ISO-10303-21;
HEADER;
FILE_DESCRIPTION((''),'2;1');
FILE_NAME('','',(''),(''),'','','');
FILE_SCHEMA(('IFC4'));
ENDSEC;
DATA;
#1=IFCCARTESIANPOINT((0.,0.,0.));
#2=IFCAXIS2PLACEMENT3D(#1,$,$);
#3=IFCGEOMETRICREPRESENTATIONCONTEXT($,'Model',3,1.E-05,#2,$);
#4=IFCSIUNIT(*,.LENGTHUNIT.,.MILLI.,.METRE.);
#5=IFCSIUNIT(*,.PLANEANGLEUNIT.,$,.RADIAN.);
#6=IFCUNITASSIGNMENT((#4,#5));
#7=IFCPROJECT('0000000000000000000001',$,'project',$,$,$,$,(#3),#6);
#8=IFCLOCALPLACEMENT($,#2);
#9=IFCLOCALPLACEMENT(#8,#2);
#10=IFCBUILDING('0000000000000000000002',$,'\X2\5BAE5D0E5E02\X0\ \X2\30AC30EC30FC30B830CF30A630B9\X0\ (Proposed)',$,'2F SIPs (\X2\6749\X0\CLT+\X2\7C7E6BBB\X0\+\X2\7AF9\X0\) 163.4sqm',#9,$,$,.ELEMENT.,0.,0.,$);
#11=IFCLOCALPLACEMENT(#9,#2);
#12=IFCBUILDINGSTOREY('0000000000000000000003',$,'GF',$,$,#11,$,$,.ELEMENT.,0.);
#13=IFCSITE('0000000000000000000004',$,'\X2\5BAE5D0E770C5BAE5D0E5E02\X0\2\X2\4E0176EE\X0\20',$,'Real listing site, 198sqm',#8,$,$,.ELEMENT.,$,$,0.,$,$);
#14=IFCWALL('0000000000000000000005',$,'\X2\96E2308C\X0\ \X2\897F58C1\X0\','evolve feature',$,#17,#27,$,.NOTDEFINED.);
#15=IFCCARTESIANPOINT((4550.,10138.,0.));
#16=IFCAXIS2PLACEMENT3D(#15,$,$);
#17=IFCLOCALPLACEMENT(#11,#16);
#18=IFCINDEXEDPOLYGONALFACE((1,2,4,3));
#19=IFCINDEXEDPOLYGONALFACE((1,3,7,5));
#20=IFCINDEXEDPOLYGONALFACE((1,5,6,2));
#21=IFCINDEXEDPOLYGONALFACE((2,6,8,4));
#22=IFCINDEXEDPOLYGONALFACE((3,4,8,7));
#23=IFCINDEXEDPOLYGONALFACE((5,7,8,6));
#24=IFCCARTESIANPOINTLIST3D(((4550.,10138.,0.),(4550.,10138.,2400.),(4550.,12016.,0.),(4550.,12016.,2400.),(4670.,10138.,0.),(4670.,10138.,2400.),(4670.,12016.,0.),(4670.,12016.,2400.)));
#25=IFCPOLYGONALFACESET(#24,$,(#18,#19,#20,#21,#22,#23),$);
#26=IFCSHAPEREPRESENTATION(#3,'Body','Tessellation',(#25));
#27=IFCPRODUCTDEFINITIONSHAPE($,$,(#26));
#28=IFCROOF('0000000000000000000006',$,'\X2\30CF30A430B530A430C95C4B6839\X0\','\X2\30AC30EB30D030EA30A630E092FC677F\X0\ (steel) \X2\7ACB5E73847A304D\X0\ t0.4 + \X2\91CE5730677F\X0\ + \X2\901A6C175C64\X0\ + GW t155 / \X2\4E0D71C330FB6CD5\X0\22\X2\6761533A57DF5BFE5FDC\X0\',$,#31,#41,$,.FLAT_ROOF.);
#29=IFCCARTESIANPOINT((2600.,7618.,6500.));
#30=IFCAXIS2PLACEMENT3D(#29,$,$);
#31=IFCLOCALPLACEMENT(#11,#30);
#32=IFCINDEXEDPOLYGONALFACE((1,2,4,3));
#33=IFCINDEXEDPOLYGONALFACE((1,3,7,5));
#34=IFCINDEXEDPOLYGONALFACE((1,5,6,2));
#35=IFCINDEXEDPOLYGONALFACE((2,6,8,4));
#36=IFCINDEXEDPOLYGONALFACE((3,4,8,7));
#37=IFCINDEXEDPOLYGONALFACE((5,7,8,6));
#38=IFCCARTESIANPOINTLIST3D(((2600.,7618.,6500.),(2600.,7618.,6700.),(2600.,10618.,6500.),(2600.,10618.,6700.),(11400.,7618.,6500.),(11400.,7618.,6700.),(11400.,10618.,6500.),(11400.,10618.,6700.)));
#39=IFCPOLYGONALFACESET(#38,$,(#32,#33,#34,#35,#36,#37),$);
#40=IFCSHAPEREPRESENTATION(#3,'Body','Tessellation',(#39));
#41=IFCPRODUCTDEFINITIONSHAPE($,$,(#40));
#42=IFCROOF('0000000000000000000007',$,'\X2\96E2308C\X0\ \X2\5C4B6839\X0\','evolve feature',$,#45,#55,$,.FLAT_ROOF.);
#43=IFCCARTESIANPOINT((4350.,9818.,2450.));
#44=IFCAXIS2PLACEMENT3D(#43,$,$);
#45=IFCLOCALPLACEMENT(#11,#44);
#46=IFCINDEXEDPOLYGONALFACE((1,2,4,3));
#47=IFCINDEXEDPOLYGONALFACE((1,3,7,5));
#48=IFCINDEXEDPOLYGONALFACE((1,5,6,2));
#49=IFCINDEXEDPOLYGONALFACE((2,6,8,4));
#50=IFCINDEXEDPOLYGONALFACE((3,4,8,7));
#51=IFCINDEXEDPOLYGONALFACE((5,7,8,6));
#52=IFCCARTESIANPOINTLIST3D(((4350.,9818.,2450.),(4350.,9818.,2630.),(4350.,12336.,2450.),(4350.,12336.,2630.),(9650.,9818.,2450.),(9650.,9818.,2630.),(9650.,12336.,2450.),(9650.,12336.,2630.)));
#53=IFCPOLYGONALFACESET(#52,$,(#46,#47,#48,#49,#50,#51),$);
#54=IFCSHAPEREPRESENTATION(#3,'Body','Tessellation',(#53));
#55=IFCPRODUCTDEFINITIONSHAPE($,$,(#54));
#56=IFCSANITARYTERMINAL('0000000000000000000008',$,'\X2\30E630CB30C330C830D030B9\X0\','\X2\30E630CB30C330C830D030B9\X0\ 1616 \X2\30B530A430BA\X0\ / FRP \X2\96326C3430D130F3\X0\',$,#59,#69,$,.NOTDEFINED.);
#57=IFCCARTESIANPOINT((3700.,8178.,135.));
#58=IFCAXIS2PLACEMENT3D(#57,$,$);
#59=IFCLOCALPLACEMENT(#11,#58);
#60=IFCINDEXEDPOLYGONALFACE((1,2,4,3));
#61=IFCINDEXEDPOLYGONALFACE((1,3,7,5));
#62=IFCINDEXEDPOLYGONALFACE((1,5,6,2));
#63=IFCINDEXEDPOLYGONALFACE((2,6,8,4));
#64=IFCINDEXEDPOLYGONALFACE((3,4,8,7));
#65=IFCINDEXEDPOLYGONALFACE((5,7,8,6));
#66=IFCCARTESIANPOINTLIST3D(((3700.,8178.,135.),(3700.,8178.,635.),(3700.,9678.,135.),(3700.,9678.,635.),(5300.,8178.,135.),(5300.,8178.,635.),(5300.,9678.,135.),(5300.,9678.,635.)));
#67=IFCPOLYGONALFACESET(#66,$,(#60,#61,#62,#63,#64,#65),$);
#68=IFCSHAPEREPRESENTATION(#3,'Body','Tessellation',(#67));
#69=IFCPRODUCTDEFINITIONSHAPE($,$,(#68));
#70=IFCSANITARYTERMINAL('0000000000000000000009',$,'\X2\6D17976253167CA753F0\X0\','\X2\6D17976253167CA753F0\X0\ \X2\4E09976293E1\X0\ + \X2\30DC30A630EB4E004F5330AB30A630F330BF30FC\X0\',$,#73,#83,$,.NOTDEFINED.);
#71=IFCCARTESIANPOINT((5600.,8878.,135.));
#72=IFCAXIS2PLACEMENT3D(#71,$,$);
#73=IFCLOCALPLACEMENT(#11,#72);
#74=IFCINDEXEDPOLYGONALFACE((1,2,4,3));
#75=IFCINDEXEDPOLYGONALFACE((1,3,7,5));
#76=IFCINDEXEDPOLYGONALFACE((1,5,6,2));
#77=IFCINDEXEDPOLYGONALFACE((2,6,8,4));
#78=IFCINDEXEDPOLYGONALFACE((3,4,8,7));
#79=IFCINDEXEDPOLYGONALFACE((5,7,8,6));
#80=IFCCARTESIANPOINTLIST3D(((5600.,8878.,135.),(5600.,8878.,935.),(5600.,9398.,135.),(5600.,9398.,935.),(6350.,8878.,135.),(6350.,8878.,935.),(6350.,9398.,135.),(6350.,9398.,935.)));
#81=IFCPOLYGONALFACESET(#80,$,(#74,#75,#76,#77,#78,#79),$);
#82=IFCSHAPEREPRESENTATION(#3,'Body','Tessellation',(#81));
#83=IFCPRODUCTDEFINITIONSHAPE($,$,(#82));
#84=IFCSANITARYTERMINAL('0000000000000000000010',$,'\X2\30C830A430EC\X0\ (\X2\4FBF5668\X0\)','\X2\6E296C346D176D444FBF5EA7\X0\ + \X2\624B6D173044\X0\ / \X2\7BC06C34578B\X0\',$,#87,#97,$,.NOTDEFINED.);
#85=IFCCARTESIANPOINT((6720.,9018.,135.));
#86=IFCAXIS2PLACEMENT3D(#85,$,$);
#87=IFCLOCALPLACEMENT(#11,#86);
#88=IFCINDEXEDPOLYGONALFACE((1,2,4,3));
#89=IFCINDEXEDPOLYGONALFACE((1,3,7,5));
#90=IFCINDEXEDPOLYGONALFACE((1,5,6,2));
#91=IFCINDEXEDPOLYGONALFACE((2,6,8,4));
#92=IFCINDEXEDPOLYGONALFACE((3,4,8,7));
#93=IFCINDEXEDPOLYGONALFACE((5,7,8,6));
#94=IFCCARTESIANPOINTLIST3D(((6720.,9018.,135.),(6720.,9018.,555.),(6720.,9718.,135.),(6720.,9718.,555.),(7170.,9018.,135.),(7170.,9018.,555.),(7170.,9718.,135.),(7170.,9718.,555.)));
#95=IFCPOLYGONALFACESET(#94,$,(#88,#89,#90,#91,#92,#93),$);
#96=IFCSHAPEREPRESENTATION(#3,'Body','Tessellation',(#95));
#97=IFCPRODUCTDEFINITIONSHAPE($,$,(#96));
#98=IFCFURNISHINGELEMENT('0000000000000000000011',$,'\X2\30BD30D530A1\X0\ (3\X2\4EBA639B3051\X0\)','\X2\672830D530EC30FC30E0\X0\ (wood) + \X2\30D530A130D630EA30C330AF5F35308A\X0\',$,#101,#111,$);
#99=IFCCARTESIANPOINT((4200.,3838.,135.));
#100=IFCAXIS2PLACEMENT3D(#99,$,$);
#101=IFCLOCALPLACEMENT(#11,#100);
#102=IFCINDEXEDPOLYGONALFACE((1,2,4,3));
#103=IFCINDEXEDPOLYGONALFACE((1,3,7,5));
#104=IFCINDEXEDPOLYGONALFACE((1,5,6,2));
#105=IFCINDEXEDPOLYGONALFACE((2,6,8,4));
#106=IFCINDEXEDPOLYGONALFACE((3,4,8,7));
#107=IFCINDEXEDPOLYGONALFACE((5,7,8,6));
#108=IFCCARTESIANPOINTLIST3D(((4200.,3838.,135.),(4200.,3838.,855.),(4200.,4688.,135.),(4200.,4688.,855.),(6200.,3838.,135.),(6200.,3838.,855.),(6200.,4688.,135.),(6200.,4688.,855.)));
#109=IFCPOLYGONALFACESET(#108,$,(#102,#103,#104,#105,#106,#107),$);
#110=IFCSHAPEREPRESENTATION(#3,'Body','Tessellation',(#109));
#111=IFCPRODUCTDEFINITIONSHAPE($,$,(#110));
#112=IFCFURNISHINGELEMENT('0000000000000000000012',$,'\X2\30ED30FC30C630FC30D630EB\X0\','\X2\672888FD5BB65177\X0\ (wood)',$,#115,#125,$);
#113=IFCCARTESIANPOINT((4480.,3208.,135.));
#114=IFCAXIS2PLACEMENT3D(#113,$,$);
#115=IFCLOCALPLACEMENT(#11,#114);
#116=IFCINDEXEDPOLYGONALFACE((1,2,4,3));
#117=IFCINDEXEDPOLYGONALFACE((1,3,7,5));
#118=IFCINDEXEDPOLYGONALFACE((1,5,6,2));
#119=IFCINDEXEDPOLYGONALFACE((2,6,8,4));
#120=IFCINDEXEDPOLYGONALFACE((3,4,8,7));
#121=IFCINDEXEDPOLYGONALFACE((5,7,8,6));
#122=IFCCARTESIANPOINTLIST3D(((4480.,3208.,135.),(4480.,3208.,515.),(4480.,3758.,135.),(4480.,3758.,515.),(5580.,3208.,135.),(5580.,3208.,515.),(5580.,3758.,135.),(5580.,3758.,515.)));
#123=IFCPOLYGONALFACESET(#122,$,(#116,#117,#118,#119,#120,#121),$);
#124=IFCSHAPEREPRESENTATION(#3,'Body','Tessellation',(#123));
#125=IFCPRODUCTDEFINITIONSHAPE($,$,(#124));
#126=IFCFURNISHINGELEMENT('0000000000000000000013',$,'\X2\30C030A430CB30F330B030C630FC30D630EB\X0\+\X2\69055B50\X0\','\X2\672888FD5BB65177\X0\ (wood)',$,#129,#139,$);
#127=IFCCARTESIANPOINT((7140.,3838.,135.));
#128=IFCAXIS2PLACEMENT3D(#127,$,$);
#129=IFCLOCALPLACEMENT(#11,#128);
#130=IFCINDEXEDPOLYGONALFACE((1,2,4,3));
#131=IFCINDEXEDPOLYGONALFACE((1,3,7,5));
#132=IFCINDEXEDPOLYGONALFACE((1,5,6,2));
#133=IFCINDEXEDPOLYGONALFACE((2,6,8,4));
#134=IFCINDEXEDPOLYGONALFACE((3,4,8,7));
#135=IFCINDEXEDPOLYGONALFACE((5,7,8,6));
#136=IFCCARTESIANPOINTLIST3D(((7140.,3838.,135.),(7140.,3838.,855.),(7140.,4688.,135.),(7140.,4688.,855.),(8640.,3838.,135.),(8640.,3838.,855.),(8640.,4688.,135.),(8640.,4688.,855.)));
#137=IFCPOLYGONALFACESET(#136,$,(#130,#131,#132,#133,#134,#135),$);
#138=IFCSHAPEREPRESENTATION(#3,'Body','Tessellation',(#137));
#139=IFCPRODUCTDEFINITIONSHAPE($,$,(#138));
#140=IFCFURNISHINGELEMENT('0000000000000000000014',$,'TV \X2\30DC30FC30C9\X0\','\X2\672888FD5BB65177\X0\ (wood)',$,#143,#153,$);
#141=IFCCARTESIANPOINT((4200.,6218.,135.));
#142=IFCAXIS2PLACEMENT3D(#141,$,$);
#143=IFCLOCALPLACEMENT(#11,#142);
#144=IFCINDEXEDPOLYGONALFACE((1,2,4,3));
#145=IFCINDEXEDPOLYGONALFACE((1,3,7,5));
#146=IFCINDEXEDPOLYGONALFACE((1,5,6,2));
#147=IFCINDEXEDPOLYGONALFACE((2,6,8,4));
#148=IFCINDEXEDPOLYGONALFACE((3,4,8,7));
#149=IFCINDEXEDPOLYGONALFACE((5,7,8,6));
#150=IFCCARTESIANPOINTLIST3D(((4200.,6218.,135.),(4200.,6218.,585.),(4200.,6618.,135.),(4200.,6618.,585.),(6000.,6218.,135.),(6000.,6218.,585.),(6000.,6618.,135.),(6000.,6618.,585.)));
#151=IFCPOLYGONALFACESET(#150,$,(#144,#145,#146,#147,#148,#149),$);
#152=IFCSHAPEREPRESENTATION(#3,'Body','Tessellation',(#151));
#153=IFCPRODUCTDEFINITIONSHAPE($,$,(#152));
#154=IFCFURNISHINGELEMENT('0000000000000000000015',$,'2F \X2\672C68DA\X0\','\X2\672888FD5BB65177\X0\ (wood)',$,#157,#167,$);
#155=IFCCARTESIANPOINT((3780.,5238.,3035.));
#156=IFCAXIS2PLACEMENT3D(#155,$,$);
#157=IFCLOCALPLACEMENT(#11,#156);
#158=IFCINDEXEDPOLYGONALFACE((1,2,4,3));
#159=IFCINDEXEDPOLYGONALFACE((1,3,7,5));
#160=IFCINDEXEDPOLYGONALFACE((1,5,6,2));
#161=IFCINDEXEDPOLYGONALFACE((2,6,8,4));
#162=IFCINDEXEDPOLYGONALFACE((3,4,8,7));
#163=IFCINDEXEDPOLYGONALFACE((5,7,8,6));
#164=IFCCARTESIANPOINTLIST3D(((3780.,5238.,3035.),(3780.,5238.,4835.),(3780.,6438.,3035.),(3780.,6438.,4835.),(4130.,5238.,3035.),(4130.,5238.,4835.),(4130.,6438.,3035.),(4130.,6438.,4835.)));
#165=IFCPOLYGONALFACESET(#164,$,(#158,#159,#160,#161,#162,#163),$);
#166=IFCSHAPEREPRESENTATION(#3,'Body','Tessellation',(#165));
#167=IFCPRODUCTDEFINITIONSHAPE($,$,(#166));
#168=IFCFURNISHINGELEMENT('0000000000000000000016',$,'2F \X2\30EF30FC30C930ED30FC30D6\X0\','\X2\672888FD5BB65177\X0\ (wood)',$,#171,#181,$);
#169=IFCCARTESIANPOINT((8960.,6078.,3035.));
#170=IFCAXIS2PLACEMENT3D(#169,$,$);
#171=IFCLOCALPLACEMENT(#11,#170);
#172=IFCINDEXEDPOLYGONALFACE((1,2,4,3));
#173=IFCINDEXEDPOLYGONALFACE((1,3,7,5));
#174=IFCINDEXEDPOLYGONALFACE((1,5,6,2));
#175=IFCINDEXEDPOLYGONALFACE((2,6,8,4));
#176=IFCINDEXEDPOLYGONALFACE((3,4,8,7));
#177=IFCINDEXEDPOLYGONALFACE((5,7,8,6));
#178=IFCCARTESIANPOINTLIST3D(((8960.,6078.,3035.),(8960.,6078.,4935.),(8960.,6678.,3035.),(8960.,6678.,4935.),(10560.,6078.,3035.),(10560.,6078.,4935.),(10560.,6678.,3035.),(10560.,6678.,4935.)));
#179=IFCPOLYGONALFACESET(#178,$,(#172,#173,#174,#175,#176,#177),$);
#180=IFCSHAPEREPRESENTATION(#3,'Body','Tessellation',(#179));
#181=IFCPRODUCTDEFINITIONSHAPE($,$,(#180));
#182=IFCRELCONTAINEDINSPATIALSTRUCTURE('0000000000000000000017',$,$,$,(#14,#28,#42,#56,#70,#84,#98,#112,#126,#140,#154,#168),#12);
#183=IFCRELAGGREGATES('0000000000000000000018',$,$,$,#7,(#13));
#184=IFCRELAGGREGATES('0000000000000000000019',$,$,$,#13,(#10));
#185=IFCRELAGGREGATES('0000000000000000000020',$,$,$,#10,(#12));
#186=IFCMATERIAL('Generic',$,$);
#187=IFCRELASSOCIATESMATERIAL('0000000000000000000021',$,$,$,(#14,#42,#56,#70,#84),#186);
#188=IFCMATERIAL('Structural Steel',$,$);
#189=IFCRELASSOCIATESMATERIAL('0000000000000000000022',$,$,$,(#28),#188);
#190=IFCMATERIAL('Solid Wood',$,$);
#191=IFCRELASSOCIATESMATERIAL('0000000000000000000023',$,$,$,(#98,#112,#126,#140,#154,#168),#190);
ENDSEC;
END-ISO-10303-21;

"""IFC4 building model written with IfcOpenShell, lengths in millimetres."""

from ifc_helpers import new_model, si_unit, frame, frame_2d, origin, place, context, project, spatial, rectangle, extrude, material, element, save


model = new_model("IFC4")

# Units and contexts
model_context = context("Model", 3, precision=1e-05, world=origin())
ifc_project = project(units=[si_unit("LENGTHUNIT", "METRE", prefix="MILLI"), si_unit("PLANEANGLEUNIT", "RADIAN")], contexts=[model_context])

# Site, building, storey
site_placement = place(None, origin())
site = spatial("IfcSite", under=ifc_project, at=site_placement, Name="宮崎県宮崎市2丁目20", ObjectType="Real listing site, 198sqm", CompositionType="ELEMENT", RefElevation=0.0)
building_placement = place(site_placement, origin())
building = spatial("IfcBuilding", under=site, at=building_placement, Name="宮崎市 ガレージハウス (Proposed)", ObjectType="2F SIPs (杉CLT+籾殻+竹) 163.4sqm", CompositionType="ELEMENT", ElevationOfRefHeight=0.0, ElevationOfTerrain=0.0)
storey_placement = place(building_placement, origin())
storey = spatial("IfcBuildingStorey", under=building, at=storey_placement, Name="GF", CompositionType="ELEMENT", Elevation=0.0)

# Shared definitions
ifc_material_1 = material(Name="Generic")

# Shared definitions
ifc_material_2 = material(Name="Solid Wood")

# Wall
wall_1_placement = place(storey_placement, frame((4550.0, 10138.0, 0.0)))
element("IfcWall", 1, at=wall_1_placement, inside=storey, material=ifc_material_1, Name="離れ 西壁", Description="evolve feature", PredefinedType="NOTDEFINED", context=model_context, shape_type="SweptSolid", body=[
    extrude(rectangle(XDim=120.0, YDim=1878.0, at=frame_2d((60.0, 939.0))), frame((4550.0, 10138.0, 0.0)), (0.0, 0.0, 1.0), 2400.0),
])

# Roofs
ifc_material_3 = material(Name="Structural Steel")
roof_1_placement = place(storey_placement, frame((2600.0, 7618.0, 6500.0)))
element("IfcRoof", 2, at=roof_1_placement, inside=storey, material=ifc_material_3, Name="ハイサイド屋根", Description="ガルバリウム鋼板 (steel) 立平葺き t0.4 + 野地板 + 通気層 + GW t155 / 不燃・法22条区域対応", PredefinedType="FLAT_ROOF", context=model_context, shape_type="SweptSolid", body=[
    extrude(rectangle(XDim=8800.0, YDim=3000.0, at=frame_2d((4400.0, 1500.0))), frame((2600.0, 7618.0, 6500.0)), (0.0, 0.0, 1.0), 200.0),
])
roof_2_placement = place(storey_placement, frame((4350.0, 9818.0, 2450.0)))
element("IfcRoof", 3, at=roof_2_placement, inside=storey, material=ifc_material_1, Name="離れ 屋根", Description="evolve feature", PredefinedType="FLAT_ROOF", context=model_context, shape_type="SweptSolid", body=[
    extrude(rectangle(XDim=5300.0, YDim=2518.0, at=frame_2d((2650.0, 1259.0))), frame((4350.0, 9818.0, 2450.0)), (0.0, 0.0, 1.0), 180.0),
])

# Sanitary terminals
sanitary_terminal_1_placement = place(storey_placement, frame((3700.0, 8178.0, 135.0)))
element("IfcSanitaryTerminal", 4, at=sanitary_terminal_1_placement, inside=storey, material=ifc_material_1, Name="ユニットバス", Description="ユニットバス 1616 サイズ / FRP 防水パン", PredefinedType="NOTDEFINED", context=model_context, shape_type="SweptSolid", body=[
    extrude(rectangle(XDim=1600.0, YDim=1500.0, at=frame_2d((800.0, 750.0))), frame((3700.0, 8178.0, 135.0)), (0.0, 0.0, 1.0), 500.0),
])
sanitary_terminal_2_placement = place(storey_placement, frame((5600.0, 8878.0, 135.0)))
element("IfcSanitaryTerminal", 5, at=sanitary_terminal_2_placement, inside=storey, material=ifc_material_1, Name="洗面化粧台", Description="洗面化粧台 三面鏡 + ボウル一体カウンター", PredefinedType="NOTDEFINED", context=model_context, shape_type="SweptSolid", body=[
    extrude(rectangle(XDim=750.0, YDim=520.0, at=frame_2d((375.0, 260.0))), frame((5600.0, 8878.0, 135.0)), (0.0, 0.0, 1.0), 800.0),
])
sanitary_terminal_3_placement = place(storey_placement, frame((6720.0, 9018.0, 135.0)))
element("IfcSanitaryTerminal", 6, at=sanitary_terminal_3_placement, inside=storey, material=ifc_material_1, Name="トイレ (便器)", Description="温水洗浄便座 + 手洗い / 節水型", PredefinedType="NOTDEFINED", context=model_context, shape_type="SweptSolid", body=[
    extrude(rectangle(XDim=450.0, YDim=700.0, at=frame_2d((225.0, 350.0))), frame((6720.0, 9018.0, 135.0)), (0.0, 0.0, 1.0), 420.0),
])

# Furnishing elements
furnishing_1_placement = place(storey_placement, frame((4200.0, 3838.0, 135.0)))
element("IfcFurnishingElement", 7, at=furnishing_1_placement, inside=storey, material=ifc_material_2, Name="ソファ (3人掛け)", Description="木フレーム (wood) + ファブリック張り", context=model_context, shape_type="SweptSolid", body=[
    extrude(rectangle(XDim=2000.0, YDim=850.0, at=frame_2d((1000.0, 425.0))), frame((4200.0, 3838.0, 135.0)), (0.0, 0.0, 1.0), 720.0),
])
furnishing_2_placement = place(storey_placement, frame((4480.0, 3208.0, 135.0)))
element("IfcFurnishingElement", 8, at=furnishing_2_placement, inside=storey, material=ifc_material_2, Name="ローテーブル", Description="木製家具 (wood)", context=model_context, shape_type="SweptSolid", body=[
    extrude(rectangle(XDim=1100.0, YDim=550.0, at=frame_2d((550.0, 275.0))), frame((4480.0, 3208.0, 135.0)), (0.0, 0.0, 1.0), 380.0),
])
furnishing_3_placement = place(storey_placement, frame((7140.0, 3838.0, 135.0)))
element("IfcFurnishingElement", 9, at=furnishing_3_placement, inside=storey, material=ifc_material_2, Name="ダイニングテーブル+椅子", Description="木製家具 (wood)", context=model_context, shape_type="SweptSolid", body=[
    extrude(rectangle(XDim=1500.0, YDim=850.0, at=frame_2d((750.0, 425.0))), frame((7140.0, 3838.0, 135.0)), (0.0, 0.0, 1.0), 720.0),
])
furnishing_4_placement = place(storey_placement, frame((4200.0, 6218.0, 135.0)))
element("IfcFurnishingElement", 10, at=furnishing_4_placement, inside=storey, material=ifc_material_2, Name="TV ボード", Description="木製家具 (wood)", context=model_context, shape_type="SweptSolid", body=[
    extrude(rectangle(XDim=1800.0, YDim=400.0, at=frame_2d((900.0, 200.0))), frame((4200.0, 6218.0, 135.0)), (0.0, 0.0, 1.0), 450.0),
])
furnishing_5_placement = place(storey_placement, frame((3780.0, 5238.0, 3035.0)))
element("IfcFurnishingElement", 11, at=furnishing_5_placement, inside=storey, material=ifc_material_2, Name="2F 本棚", Description="木製家具 (wood)", context=model_context, shape_type="SweptSolid", body=[
    extrude(rectangle(XDim=350.0, YDim=1200.0, at=frame_2d((175.0, 600.0))), frame((3780.0, 5238.0, 3035.0)), (0.0, 0.0, 1.0), 1800.0),
])
furnishing_6_placement = place(storey_placement, frame((8960.0, 6078.0, 3035.0)))
element("IfcFurnishingElement", 12, at=furnishing_6_placement, inside=storey, material=ifc_material_2, Name="2F ワードローブ", Description="木製家具 (wood)", context=model_context, shape_type="SweptSolid", body=[
    extrude(rectangle(XDim=1600.0, YDim=600.0, at=frame_2d((800.0, 300.0))), frame((8960.0, 6078.0, 3035.0)), (0.0, 0.0, 1.0), 1900.0),
])

save(model, "model.ifc")
